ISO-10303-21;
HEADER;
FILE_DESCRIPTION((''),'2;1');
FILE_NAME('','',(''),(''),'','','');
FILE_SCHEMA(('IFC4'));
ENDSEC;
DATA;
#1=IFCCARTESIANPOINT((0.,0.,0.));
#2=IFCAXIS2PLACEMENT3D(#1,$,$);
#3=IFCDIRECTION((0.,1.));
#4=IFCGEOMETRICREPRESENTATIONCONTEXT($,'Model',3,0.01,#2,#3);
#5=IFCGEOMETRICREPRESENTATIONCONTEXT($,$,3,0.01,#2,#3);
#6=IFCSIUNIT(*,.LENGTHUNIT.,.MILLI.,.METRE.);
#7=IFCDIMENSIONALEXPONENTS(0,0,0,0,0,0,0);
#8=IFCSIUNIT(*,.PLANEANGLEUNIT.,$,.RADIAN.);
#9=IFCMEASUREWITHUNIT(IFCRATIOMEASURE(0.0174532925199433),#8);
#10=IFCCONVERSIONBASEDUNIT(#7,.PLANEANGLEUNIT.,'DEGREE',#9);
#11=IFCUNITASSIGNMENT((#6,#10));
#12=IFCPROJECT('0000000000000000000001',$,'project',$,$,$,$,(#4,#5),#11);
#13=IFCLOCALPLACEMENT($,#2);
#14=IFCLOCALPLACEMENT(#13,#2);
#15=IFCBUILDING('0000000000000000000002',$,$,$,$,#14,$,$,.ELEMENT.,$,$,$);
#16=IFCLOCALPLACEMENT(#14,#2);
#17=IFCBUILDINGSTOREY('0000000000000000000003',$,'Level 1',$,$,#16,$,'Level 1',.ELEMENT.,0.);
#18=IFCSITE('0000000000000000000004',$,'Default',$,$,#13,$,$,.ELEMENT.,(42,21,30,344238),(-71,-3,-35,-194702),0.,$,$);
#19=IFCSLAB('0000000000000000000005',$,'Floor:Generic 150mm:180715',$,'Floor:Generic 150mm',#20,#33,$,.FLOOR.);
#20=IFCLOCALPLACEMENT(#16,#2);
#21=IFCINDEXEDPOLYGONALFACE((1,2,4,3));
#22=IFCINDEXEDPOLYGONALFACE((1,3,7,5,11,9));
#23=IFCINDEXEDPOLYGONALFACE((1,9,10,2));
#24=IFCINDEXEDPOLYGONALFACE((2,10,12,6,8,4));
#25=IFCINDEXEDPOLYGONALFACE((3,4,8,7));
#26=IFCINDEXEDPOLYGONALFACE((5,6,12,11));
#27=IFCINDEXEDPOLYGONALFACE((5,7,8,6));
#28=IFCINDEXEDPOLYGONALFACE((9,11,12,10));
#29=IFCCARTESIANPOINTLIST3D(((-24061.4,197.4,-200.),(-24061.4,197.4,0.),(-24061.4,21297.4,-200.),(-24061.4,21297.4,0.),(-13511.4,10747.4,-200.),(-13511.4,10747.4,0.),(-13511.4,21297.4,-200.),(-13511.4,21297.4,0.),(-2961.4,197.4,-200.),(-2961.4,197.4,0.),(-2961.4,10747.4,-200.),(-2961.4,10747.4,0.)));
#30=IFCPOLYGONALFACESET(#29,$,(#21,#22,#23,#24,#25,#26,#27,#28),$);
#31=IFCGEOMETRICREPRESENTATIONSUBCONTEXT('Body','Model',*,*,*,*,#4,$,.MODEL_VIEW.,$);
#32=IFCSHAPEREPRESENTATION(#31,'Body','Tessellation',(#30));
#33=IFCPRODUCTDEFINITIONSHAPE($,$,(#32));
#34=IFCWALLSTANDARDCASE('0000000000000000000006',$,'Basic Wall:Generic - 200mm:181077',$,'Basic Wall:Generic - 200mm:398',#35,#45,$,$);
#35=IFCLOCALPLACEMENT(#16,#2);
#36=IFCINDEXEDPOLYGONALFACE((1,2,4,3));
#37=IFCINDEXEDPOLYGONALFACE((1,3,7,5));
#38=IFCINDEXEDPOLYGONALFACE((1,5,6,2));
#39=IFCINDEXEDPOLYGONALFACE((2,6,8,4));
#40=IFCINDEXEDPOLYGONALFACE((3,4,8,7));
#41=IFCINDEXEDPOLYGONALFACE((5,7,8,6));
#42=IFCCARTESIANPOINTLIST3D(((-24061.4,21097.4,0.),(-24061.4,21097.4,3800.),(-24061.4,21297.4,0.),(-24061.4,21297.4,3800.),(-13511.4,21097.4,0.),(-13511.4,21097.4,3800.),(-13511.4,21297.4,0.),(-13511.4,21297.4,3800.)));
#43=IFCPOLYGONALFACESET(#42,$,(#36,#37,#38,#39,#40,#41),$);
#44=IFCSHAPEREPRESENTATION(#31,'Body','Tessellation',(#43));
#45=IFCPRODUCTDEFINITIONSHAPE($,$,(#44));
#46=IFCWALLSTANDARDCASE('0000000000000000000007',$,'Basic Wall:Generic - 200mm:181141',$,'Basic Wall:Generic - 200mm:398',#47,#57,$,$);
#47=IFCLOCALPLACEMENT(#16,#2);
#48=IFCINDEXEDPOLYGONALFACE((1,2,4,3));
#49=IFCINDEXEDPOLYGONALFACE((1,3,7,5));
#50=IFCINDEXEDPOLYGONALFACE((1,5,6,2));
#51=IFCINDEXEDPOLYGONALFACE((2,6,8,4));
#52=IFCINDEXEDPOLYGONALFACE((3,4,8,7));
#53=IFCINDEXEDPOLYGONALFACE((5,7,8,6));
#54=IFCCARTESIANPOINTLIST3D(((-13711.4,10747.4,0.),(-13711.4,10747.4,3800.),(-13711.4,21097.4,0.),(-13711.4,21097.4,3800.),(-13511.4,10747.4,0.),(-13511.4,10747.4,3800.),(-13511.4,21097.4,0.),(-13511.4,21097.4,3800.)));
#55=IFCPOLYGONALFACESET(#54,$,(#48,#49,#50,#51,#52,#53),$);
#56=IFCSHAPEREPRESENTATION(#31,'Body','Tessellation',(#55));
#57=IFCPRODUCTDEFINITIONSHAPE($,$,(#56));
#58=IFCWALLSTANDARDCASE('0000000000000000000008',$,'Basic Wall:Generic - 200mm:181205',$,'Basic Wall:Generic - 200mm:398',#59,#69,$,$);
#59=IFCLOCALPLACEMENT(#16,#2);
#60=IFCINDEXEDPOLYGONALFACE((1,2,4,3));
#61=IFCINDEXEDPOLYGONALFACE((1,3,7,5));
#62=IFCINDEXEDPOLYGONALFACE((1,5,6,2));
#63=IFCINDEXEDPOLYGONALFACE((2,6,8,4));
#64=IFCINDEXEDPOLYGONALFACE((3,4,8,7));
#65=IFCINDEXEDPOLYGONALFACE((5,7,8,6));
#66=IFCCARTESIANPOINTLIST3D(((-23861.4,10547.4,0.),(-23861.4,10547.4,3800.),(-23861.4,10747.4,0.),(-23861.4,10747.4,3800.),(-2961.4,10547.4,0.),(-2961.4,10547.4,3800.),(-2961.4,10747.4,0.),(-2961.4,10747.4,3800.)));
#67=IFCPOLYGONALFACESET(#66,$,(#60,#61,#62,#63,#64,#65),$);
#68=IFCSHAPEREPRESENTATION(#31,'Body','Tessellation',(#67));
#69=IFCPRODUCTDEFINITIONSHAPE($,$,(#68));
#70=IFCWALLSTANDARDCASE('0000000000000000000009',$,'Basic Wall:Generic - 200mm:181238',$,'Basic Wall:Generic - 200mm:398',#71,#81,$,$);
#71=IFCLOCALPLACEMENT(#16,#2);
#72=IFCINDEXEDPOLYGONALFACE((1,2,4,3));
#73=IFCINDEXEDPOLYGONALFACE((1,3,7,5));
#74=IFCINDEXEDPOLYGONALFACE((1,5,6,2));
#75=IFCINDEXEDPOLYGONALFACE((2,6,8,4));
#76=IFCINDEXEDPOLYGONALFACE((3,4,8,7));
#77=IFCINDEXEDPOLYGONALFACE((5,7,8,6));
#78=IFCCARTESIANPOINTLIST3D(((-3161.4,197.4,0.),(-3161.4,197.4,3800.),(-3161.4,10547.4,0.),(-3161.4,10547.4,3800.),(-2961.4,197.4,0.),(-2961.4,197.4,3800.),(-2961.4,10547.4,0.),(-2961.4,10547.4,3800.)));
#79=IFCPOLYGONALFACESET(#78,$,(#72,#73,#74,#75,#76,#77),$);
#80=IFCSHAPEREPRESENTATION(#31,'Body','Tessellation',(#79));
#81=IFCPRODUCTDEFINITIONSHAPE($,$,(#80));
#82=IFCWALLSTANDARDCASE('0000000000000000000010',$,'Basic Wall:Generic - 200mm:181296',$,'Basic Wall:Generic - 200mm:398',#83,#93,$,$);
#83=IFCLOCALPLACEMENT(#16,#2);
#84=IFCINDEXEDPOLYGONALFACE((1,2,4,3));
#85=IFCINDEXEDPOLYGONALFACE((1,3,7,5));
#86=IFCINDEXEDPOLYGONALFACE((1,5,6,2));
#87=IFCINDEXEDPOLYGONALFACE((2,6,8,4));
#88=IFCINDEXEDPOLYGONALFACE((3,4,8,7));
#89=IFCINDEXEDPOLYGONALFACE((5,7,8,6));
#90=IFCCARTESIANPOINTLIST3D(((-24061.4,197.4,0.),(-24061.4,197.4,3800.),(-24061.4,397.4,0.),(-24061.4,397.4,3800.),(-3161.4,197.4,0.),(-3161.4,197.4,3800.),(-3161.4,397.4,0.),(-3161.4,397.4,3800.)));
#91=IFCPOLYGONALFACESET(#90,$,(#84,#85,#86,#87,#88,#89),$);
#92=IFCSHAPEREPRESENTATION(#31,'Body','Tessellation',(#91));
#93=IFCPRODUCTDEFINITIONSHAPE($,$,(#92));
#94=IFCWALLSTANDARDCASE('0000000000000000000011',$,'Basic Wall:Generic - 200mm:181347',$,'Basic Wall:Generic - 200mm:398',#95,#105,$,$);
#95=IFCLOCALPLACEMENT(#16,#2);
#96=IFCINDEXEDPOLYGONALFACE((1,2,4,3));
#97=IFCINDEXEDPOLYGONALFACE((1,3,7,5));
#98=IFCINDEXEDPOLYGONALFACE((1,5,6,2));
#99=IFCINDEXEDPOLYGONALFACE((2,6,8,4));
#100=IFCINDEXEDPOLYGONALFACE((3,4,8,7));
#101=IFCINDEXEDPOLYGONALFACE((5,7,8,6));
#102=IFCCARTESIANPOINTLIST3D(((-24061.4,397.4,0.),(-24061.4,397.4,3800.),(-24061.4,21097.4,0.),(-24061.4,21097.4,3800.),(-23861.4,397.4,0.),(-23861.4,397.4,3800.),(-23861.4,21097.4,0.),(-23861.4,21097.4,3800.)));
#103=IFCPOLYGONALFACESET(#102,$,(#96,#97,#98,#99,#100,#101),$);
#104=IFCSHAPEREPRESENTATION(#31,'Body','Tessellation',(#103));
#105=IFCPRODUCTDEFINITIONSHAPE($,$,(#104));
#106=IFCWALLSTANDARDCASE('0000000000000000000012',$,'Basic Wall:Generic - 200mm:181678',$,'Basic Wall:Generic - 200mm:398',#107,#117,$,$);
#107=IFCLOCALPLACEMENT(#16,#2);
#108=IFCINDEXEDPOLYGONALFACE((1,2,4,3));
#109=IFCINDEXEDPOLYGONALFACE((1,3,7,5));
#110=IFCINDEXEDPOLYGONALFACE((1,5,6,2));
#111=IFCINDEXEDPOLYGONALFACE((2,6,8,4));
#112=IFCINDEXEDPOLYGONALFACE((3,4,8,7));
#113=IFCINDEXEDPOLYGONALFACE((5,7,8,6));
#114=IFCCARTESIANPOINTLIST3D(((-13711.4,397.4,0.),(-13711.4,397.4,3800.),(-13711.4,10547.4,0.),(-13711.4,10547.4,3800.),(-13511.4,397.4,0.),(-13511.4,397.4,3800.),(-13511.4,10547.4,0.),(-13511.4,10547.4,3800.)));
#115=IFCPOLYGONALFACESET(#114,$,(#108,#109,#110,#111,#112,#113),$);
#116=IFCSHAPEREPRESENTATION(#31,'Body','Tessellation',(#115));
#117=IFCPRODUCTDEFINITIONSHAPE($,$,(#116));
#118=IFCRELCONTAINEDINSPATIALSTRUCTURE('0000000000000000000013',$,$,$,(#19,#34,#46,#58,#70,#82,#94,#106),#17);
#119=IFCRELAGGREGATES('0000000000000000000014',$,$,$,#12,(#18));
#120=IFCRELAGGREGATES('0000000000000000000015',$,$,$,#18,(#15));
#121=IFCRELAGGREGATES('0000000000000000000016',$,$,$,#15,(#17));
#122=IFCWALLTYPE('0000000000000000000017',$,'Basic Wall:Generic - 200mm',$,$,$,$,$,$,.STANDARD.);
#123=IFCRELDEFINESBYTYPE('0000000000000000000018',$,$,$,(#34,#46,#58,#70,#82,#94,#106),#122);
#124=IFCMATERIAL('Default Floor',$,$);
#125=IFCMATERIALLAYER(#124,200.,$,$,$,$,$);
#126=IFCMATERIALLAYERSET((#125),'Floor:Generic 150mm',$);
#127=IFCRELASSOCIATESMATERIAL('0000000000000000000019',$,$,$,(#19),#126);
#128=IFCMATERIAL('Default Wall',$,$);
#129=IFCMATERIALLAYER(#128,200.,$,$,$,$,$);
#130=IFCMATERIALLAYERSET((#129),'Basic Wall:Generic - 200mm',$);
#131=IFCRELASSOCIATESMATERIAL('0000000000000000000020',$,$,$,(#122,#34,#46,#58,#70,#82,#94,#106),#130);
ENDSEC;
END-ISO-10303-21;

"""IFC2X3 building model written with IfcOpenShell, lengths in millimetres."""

from ifc_helpers import new_model, entity, si_unit, converted_unit, direction, frame, frame_2d, origin, place, context, subcontext, project, spatial, polyline, rectangle, outline, extrude, material, layer, layer_set, layer_usage, type_object, element, save


model = new_model("IFC2X3")

# Units and contexts
model_context = context("Model", 3, precision=0.01, world=origin(), true_north=direction((0.0, 1.0)))
context_of_model = context(None, 3, precision=0.01, world=origin(), true_north=direction((0.0, 1.0)))
body_context = subcontext(model_context, "Body", "Model", "MODEL_VIEW")
ifc_project = project(units=[si_unit("LENGTHUNIT", "METRE", prefix="MILLI"), converted_unit("PLANEANGLEUNIT", "DEGREE", entity("IfcRatioMeasure", 0.0174532925199433), si_unit("PLANEANGLEUNIT", "RADIAN"), dimensions=[0, 0, 0, 0, 0, 0, 0])], contexts=[model_context, context_of_model])

# Site, building, storey
site_placement = place(None, origin())
site = spatial("IfcSite", under=ifc_project, at=site_placement, Name="Default", CompositionType="ELEMENT", RefLatitude=(42, 21, 30, 344238), RefLongitude=(-71, -3, -35, -194702), RefElevation=0.0)
building_placement = place(site_placement, origin())
building = spatial("IfcBuilding", under=site, at=building_placement, CompositionType="ELEMENT")
storey_placement = place(building_placement, origin())
storey = spatial("IfcBuildingStorey", under=building, at=storey_placement, Name="Level 1", LongName="Level 1", CompositionType="ELEMENT", Elevation=0.0)

# Slab
ifc_material_1 = material(Name="Default Floor")
ifc_layer_1 = layer(ifc_material_1, 200.0)
ifc_layer_set_1 = layer_set([ifc_layer_1], Name="Floor:Generic 150mm")
ifc_layer_usage_1 = layer_usage(ifc_layer_set_1, "AXIS3", "POSITIVE", 0.0)
slab_placement = place(storey_placement, origin())
element("IfcSlab", 1, at=slab_placement, inside=storey, material=ifc_layer_usage_1, Name="Floor:Generic 150mm:180715", ObjectType="Floor:Generic 150mm", PredefinedType="FLOOR", context=body_context, shape_type="SweptSolid", body=[
    extrude(outline(polyline([(-10550.0, -10550.0), (10550.0, -10550.0), (10550.0, 0.0), (0.0, 0.0), (0.0, 10550.0), (-10550.0, 10550.0), (-10550.0, -10550.0)])), frame((-13511.4, 10747.4, 0.0), z_axis=(0.0, 0.0, -1.0), x_axis=(0.0, 1.0, 0.0)), (0.0, 0.0, 1.0), 200.0),
])

# Walls
ifc_material_2 = material(Name="Default Wall")
ifc_layer_2 = layer(ifc_material_2, 200.0)
ifc_layer_set_2 = layer_set([ifc_layer_2], Name="Basic Wall:Generic - 200mm")
ifc_layer_usage_2 = layer_usage(ifc_layer_set_2, "AXIS2", "NEGATIVE", 100.0)
wall_type = type_object("IfcWallType", Name="Basic Wall:Generic - 200mm", PredefinedType="STANDARD", material=ifc_layer_set_2)
wall_1_placement = place(storey_placement, frame((-24061.4, 21197.4, 0.0)))
element("IfcWallStandardCase", 2, at=wall_1_placement, inside=storey, type_object=wall_type, material=ifc_layer_usage_2, Name="Basic Wall:Generic - 200mm:181077", ObjectType="Basic Wall:Generic - 200mm:398", context=body_context, shape_type="SweptSolid", body=[
    extrude(rectangle(XDim=10550.0, YDim=200.0, at=frame_2d((5275.0, 0.0), x_axis=(-1.0, 0.0))), origin(), (0.0, 0.0, 1.0), 3800.0),
])
ifc_layer_usage_3 = layer_usage(ifc_layer_set_2, "AXIS2", "NEGATIVE", 100.0)
wall_2_placement = place(storey_placement, frame((-13611.4, 21097.4, 0.0), z_axis=(0.0, 0.0, 1.0), x_axis=(0.0, -1.0, 0.0)))
element("IfcWallStandardCase", 3, at=wall_2_placement, inside=storey, type_object=wall_type, material=ifc_layer_usage_3, Name="Basic Wall:Generic - 200mm:181141", ObjectType="Basic Wall:Generic - 200mm:398", context=body_context, shape_type="SweptSolid", body=[
    extrude(rectangle(XDim=10350.0, YDim=200.0, at=frame_2d((5175.0, 0.0), x_axis=(-1.0, 0.0))), origin(), (0.0, 0.0, 1.0), 3800.0),
])
ifc_layer_usage_4 = layer_usage(ifc_layer_set_2, "AXIS2", "NEGATIVE", 100.0)
wall_3_placement = place(storey_placement, frame((-23861.4, 10647.4, 0.0)))
element("IfcWallStandardCase", 4, at=wall_3_placement, inside=storey, type_object=wall_type, material=ifc_layer_usage_4, Name="Basic Wall:Generic - 200mm:181205", ObjectType="Basic Wall:Generic - 200mm:398", context=body_context, shape_type="SweptSolid", body=[
    extrude(rectangle(XDim=20900.0, YDim=200.0, at=frame_2d((10450.0, 0.0), x_axis=(-1.0, 0.0))), origin(), (0.0, 0.0, 1.0), 3800.0),
])
ifc_layer_usage_5 = layer_usage(ifc_layer_set_2, "AXIS2", "NEGATIVE", 100.0)
wall_4_placement = place(storey_placement, frame((-3061.4, 10547.4, 0.0), z_axis=(0.0, 0.0, 1.0), x_axis=(0.0, -1.0, 0.0)))
element("IfcWallStandardCase", 5, at=wall_4_placement, inside=storey, type_object=wall_type, material=ifc_layer_usage_5, Name="Basic Wall:Generic - 200mm:181238", ObjectType="Basic Wall:Generic - 200mm:398", context=body_context, shape_type="SweptSolid", body=[
    extrude(rectangle(XDim=10350.0, YDim=200.0, at=frame_2d((5175.0, 0.0), x_axis=(-1.0, 0.0))), origin(), (0.0, 0.0, 1.0), 3800.0),
])
ifc_layer_usage_6 = layer_usage(ifc_layer_set_2, "AXIS2", "NEGATIVE", 100.0)
wall_5_placement = place(storey_placement, frame((-3161.4, 297.4, 0.0), z_axis=(0.0, 0.0, 1.0), x_axis=(-1.0, 0.0, 0.0)))
element("IfcWallStandardCase", 6, at=wall_5_placement, inside=storey, type_object=wall_type, material=ifc_layer_usage_6, Name="Basic Wall:Generic - 200mm:181296", ObjectType="Basic Wall:Generic - 200mm:398", context=body_context, shape_type="SweptSolid", body=[
    extrude(rectangle(XDim=20900.0, YDim=200.0, at=frame_2d((10450.0, 0.0), x_axis=(-1.0, 0.0))), origin(), (0.0, 0.0, 1.0), 3800.0),
])
ifc_layer_usage_7 = layer_usage(ifc_layer_set_2, "AXIS2", "NEGATIVE", 100.0)
wall_6_placement = place(storey_placement, frame((-23961.4, 397.4, 0.0), z_axis=(0.0, 0.0, 1.0), x_axis=(0.0, 1.0, 0.0)))
element("IfcWallStandardCase", 7, at=wall_6_placement, inside=storey, type_object=wall_type, material=ifc_layer_usage_7, Name="Basic Wall:Generic - 200mm:181347", ObjectType="Basic Wall:Generic - 200mm:398", context=body_context, shape_type="SweptSolid", body=[
    extrude(rectangle(XDim=20700.0, YDim=200.0, at=frame_2d((10350.0, 0.0), x_axis=(-1.0, 0.0))), origin(), (0.0, 0.0, 1.0), 3800.0),
])
ifc_layer_usage_8 = layer_usage(ifc_layer_set_2, "AXIS2", "NEGATIVE", 100.0)
wall_7_placement = place(storey_placement, frame((-13611.4, 10547.4, 0.0), z_axis=(0.0, 0.0, 1.0), x_axis=(0.0, -1.0, 0.0)))
element("IfcWallStandardCase", 8, at=wall_7_placement, inside=storey, type_object=wall_type, material=ifc_layer_usage_8, Name="Basic Wall:Generic - 200mm:181678", ObjectType="Basic Wall:Generic - 200mm:398", context=body_context, shape_type="SweptSolid", body=[
    extrude(rectangle(XDim=10150.0, YDim=200.0, at=frame_2d((5075.0, 0.0), x_axis=(-1.0, 0.0))), origin(), (0.0, 0.0, 1.0), 3800.0),
])

save(model, "model.ifc")
